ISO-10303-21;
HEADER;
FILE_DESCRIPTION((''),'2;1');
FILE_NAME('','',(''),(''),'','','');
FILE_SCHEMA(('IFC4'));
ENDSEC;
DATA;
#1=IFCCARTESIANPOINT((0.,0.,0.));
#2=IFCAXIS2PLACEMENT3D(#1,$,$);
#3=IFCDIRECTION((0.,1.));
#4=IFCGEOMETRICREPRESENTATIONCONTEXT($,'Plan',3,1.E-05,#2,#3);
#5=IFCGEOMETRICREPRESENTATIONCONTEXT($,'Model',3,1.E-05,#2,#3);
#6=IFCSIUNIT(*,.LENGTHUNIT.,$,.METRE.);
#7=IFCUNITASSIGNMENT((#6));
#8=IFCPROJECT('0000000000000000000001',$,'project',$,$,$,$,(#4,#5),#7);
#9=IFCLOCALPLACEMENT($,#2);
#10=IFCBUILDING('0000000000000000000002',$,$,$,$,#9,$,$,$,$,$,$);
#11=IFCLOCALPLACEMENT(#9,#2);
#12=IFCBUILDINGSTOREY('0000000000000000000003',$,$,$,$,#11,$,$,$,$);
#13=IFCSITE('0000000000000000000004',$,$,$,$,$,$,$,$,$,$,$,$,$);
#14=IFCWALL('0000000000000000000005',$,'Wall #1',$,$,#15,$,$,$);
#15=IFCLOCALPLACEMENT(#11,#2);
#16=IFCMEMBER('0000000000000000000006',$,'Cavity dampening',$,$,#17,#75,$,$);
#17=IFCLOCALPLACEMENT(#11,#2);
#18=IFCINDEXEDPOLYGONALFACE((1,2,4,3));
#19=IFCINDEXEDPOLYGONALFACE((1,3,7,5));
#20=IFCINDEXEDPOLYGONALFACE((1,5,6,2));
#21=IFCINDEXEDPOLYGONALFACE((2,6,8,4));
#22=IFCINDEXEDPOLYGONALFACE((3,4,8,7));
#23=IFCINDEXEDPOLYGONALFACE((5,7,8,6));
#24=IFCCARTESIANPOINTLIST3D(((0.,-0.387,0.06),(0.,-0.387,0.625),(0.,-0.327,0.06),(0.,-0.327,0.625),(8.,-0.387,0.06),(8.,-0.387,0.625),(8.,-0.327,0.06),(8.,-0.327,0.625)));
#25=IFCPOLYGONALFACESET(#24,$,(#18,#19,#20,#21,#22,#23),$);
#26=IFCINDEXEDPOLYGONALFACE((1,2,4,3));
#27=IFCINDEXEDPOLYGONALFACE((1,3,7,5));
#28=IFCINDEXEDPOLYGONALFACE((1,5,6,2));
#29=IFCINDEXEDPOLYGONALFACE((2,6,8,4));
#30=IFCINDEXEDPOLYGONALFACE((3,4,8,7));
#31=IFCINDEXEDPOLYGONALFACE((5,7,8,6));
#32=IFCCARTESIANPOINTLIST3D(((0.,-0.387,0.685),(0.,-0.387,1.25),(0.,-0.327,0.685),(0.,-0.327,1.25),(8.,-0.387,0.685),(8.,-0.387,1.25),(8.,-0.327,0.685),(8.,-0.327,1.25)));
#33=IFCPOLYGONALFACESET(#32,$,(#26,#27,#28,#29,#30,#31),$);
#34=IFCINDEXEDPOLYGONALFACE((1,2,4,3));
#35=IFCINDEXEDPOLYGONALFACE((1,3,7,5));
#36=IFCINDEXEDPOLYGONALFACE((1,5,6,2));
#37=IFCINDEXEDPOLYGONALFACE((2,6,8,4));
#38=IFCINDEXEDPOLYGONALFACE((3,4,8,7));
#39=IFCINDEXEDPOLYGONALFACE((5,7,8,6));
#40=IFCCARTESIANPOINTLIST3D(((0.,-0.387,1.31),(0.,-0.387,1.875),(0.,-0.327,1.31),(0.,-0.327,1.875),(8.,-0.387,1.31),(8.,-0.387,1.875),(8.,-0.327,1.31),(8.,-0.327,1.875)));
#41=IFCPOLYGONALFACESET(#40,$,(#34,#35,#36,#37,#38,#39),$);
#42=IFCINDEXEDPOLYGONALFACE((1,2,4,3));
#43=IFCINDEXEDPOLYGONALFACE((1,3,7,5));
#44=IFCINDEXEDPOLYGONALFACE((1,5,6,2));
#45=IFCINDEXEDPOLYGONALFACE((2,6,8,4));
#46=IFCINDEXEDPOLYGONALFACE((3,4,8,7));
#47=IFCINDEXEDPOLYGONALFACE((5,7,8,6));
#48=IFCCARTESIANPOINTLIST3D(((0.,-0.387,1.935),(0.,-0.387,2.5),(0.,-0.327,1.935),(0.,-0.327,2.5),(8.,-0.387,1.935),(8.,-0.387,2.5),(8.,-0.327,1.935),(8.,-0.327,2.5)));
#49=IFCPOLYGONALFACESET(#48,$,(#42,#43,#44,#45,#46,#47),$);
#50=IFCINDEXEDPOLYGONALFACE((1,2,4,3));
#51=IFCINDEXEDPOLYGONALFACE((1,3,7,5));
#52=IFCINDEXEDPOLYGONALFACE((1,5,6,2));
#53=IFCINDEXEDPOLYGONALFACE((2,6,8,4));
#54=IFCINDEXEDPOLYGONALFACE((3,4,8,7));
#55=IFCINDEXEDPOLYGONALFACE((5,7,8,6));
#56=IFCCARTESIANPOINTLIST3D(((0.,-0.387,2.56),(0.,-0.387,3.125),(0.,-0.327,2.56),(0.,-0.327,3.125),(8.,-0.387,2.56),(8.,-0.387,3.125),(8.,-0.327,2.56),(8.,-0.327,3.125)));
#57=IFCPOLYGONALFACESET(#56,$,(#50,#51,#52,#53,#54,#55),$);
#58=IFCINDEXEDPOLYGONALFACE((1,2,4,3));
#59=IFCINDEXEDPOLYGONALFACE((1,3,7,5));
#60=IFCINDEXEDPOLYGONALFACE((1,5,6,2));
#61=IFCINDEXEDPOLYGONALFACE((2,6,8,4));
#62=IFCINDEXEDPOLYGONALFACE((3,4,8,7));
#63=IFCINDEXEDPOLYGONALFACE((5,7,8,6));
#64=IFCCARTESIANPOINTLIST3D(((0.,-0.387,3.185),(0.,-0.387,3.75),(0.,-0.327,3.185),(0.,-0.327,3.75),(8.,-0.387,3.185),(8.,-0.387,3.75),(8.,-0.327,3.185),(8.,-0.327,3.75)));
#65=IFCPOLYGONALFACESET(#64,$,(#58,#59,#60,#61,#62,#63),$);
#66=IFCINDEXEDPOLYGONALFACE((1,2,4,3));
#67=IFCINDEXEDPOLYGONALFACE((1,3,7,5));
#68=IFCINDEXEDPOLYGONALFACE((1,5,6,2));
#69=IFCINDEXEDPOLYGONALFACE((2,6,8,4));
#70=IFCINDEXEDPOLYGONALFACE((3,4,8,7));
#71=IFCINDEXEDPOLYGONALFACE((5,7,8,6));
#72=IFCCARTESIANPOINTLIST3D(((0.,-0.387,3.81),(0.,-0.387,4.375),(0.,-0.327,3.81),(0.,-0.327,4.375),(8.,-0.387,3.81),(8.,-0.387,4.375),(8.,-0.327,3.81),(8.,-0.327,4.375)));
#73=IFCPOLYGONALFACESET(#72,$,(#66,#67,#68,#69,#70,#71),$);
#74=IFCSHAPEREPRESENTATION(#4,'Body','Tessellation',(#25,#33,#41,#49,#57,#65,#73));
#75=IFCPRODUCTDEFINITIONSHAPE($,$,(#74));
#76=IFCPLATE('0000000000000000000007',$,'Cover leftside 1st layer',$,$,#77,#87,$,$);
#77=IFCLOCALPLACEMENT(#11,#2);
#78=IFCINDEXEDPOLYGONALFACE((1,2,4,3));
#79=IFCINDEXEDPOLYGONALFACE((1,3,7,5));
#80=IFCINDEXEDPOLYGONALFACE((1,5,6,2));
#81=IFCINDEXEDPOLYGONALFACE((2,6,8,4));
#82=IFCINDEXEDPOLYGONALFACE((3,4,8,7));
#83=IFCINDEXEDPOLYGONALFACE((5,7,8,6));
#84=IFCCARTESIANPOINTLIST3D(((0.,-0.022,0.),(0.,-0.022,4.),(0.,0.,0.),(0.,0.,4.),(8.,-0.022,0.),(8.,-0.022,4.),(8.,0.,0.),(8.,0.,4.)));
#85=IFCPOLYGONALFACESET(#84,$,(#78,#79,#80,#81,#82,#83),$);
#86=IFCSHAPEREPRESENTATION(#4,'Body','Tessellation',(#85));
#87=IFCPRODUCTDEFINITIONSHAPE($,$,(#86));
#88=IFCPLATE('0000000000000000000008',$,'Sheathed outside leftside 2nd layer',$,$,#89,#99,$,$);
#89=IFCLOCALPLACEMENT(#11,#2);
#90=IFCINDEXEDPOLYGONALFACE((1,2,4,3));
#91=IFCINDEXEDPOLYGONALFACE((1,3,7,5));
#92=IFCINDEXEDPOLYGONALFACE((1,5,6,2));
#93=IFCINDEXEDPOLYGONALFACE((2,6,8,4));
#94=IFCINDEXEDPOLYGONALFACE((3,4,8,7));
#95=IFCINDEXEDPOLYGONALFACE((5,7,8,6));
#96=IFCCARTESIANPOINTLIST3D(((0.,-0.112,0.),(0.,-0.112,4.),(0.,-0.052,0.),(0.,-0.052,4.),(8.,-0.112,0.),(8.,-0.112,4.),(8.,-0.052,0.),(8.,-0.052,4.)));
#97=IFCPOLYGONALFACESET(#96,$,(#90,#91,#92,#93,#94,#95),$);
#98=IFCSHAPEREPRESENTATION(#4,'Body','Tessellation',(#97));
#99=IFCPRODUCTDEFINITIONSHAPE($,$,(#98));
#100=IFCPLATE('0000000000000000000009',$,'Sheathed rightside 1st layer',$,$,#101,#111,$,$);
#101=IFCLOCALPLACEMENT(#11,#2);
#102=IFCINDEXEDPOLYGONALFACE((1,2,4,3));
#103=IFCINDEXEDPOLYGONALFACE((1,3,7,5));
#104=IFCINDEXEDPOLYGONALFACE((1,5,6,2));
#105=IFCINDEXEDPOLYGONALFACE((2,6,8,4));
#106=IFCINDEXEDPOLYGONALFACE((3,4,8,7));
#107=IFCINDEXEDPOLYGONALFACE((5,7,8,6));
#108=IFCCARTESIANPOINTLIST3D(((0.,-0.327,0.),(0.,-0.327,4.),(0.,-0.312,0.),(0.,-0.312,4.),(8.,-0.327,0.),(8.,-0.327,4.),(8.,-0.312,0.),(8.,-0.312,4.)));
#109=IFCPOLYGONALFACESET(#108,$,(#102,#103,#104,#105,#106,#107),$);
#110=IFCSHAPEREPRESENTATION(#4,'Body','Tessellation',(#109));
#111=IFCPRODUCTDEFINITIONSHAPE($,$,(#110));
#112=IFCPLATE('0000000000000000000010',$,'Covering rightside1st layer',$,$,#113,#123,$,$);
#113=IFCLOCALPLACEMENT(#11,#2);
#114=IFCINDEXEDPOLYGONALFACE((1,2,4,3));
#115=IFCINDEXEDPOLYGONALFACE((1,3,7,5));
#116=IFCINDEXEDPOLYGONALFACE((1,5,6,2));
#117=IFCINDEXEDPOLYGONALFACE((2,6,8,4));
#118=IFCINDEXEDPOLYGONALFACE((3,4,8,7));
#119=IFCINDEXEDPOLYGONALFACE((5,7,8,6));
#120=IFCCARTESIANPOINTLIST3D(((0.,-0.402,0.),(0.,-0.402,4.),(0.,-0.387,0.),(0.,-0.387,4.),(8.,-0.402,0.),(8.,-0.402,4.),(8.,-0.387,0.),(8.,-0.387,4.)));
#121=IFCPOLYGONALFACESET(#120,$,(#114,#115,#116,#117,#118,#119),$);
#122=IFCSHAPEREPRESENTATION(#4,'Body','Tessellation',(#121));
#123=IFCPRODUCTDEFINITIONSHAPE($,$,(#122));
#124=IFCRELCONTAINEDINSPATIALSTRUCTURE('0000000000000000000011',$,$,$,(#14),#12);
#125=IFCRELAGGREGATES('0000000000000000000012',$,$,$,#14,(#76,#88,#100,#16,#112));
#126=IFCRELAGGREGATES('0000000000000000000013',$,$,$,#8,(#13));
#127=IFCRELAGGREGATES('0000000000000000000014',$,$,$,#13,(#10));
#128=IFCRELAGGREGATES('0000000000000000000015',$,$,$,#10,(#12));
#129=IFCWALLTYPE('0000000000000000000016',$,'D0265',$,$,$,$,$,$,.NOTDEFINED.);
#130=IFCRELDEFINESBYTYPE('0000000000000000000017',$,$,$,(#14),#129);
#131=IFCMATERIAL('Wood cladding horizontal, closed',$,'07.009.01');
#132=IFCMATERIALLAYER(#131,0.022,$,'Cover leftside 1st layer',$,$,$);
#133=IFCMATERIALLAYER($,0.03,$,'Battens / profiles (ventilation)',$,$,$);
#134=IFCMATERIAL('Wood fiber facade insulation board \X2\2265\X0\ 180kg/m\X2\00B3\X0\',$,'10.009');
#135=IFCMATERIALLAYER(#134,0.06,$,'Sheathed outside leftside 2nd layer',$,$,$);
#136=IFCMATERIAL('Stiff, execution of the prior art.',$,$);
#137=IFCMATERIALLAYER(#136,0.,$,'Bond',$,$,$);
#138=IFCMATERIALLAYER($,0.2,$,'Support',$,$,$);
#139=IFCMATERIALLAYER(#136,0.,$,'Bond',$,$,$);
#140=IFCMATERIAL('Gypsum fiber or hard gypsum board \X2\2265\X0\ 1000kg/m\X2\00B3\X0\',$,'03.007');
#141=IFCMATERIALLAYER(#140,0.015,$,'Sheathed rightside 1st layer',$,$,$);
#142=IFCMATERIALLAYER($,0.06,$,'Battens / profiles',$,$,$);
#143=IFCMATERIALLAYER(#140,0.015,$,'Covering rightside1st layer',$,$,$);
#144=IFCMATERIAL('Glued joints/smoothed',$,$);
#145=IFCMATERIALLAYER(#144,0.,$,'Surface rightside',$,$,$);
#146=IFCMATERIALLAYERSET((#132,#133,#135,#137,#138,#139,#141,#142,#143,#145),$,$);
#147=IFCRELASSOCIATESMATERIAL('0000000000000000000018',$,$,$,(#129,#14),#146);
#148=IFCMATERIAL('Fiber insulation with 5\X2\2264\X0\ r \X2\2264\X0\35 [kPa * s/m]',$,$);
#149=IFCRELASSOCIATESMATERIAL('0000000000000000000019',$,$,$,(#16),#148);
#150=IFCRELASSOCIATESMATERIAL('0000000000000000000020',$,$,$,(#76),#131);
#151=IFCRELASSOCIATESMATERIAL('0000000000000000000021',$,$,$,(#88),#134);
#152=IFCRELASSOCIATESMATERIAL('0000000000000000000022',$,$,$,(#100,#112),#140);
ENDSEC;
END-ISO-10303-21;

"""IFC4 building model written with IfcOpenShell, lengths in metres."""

from ifc_helpers import new_model, si_unit, direction, frame, frame_2d, origin, origin_with_axes, place, context, project, spatial, rectangle, extrude, material, layer, layer_set, type_object, element, aggregate, save


model = new_model("IFC4")

# Units and contexts
plan_context = context("Plan", 3, precision=1e-05, world=origin(), true_north=direction((0.0, 1.0)))
model_context = context("Model", 3, precision=1e-05, world=origin(), true_north=direction((0.0, 1.0)))
ifc_project = project(units=[si_unit("LENGTHUNIT", "METRE")], contexts=[plan_context, model_context])

# Site, building, storey
site = spatial("IfcSite", under=ifc_project)
building_placement = place(None, origin())
building = spatial("IfcBuilding", under=site, at=building_placement)
storey_placement = place(building_placement, origin())
storey = spatial("IfcBuildingStorey", under=building, at=storey_placement)

# Wall, member, plates
ifc_material_1 = material(Name="Wood cladding horizontal, closed", Category="07.009.01")
ifc_layer_1 = layer(ifc_material_1, 0.022, Name="Cover leftside 1st layer")
ifc_layer_2 = layer(None, 0.03, Name="Battens / profiles (ventilation)")
ifc_material_2 = material(Name="Wood fiber facade insulation board ≥ 180kg/m³", Category="10.009")
ifc_layer_3 = layer(ifc_material_2, 0.06, Name="Sheathed outside leftside 2nd layer")
ifc_material_3 = material(Name="Stiff, execution of the prior art.")
ifc_layer_4 = layer(ifc_material_3, 0.0, Name="Bond")
ifc_layer_5 = layer(None, 0.2, Name="Support")
ifc_layer_6 = layer(ifc_material_3, 0.0, Name="Bond")
ifc_material_4 = material(Name="Gypsum fiber or hard gypsum board ≥ 1000kg/m³", Category="03.007")
ifc_layer_7 = layer(ifc_material_4, 0.015, Name="Sheathed rightside 1st layer")
ifc_layer_8 = layer(None, 0.06, Name="Battens / profiles")
ifc_layer_9 = layer(ifc_material_4, 0.015, Name="Covering rightside1st layer")
ifc_material_5 = material(Name="Glued joints/smoothed")
ifc_layer_10 = layer(ifc_material_5, 0.0, Name="Surface rightside")
ifc_layer_set = layer_set([ifc_layer_1, ifc_layer_2, ifc_layer_3, ifc_layer_4, ifc_layer_5, ifc_layer_6, ifc_layer_7, ifc_layer_8, ifc_layer_9, ifc_layer_10])
wall_type = type_object("IfcWallType", Name="D0265", PredefinedType="NOTDEFINED", material=ifc_layer_set)
wall_placement = place(None, frame((0.0, 0.0, 0.0), z_axis=(0.0, -1.0, 0.0), x_axis=(1.0, 0.0, 0.0)))
wall = element("IfcWall", 1, at=wall_placement, inside=storey, type_object=wall_type, material=ifc_layer_set, Name="Wall #1")
ifc_material_6 = material(Name="Fiber insulation with 5≤ r ≤35 [kPa * s/m]")
member_1_placement = place(wall_placement, origin())
member_1 = element("IfcMember", 2, at=member_1_placement, material=ifc_material_6, Name="Cavity dampening", context=plan_context, shape_type="SweptSolid", body=[
    extrude(rectangle(XDim=0.565, YDim=0.06, at=frame_2d((0.2825, 0.03), x_axis=(1.0, 0.0))), frame((0.0, 0.06, 0.327), z_axis=(1.0, 0.0, 0.0), x_axis=(0.0, 1.0, 0.0)), (0.0, 0.0, 1.0), 8.0),
    extrude(rectangle(XDim=0.565, YDim=0.06, at=frame_2d((0.2825, 0.03), x_axis=(1.0, 0.0))), frame((0.0, 0.685, 0.327), z_axis=(1.0, 0.0, 0.0), x_axis=(0.0, 1.0, 0.0)), (0.0, 0.0, 1.0), 8.0),
    extrude(rectangle(XDim=0.565, YDim=0.06, at=frame_2d((0.2825, 0.03), x_axis=(1.0, 0.0))), frame((0.0, 1.31, 0.327), z_axis=(1.0, 0.0, 0.0), x_axis=(0.0, 1.0, 0.0)), (0.0, 0.0, 1.0), 8.0),
    extrude(rectangle(XDim=0.565, YDim=0.06, at=frame_2d((0.2825, 0.03), x_axis=(1.0, 0.0))), frame((0.0, 1.935, 0.327), z_axis=(1.0, 0.0, 0.0), x_axis=(0.0, 1.0, 0.0)), (0.0, 0.0, 1.0), 8.0),
    extrude(rectangle(XDim=0.565, YDim=0.06, at=frame_2d((0.2825, 0.03), x_axis=(1.0, 0.0))), frame((0.0, 2.56, 0.327), z_axis=(1.0, 0.0, 0.0), x_axis=(0.0, 1.0, 0.0)), (0.0, 0.0, 1.0), 8.0),
    extrude(rectangle(XDim=0.565, YDim=0.06, at=frame_2d((0.2825, 0.03), x_axis=(1.0, 0.0))), frame((0.0, 3.185, 0.327), z_axis=(1.0, 0.0, 0.0), x_axis=(0.0, 1.0, 0.0)), (0.0, 0.0, 1.0), 8.0),
    extrude(rectangle(XDim=0.565, YDim=0.06, at=frame_2d((0.2825, 0.03), x_axis=(1.0, 0.0))), frame((0.0, 3.81, 0.327), z_axis=(1.0, 0.0, 0.0), x_axis=(0.0, 1.0, 0.0)), (0.0, 0.0, 1.0), 8.0),
])
plate_1_placement = place(wall_placement, origin())
plate_1 = element("IfcPlate", 3, at=plate_1_placement, material=ifc_material_1, Name="Cover leftside 1st layer", context=plan_context, shape_type="SweptSolid", body=[
    extrude(rectangle(XDim=8.0, YDim=4.0, at=frame_2d((4.0, 2.0), x_axis=(1.0, 0.0))), origin_with_axes(), (0.0, 0.0, 1.0), 0.022),
])
plate_2_placement = place(wall_placement, origin())
plate_2 = element("IfcPlate", 4, at=plate_2_placement, material=ifc_material_2, Name="Sheathed outside leftside 2nd layer", context=plan_context, shape_type="SweptSolid", body=[
    extrude(rectangle(XDim=8.0, YDim=4.0, at=frame_2d((4.0, 2.0), x_axis=(1.0, 0.0))), frame((0.0, 0.0, 0.052), z_axis=(0.0, 0.0, 1.0), x_axis=(1.0, 0.0, 0.0)), (0.0, 0.0, 1.0), 0.06),
])
plate_3_placement = place(wall_placement, origin())
plate_3 = element("IfcPlate", 5, at=plate_3_placement, material=ifc_material_4, Name="Sheathed rightside 1st layer", context=plan_context, shape_type="SweptSolid", body=[
    extrude(rectangle(XDim=8.0, YDim=4.0, at=frame_2d((4.0, 2.0), x_axis=(1.0, 0.0))), frame((0.0, 0.0, 0.312), z_axis=(0.0, 0.0, 1.0), x_axis=(1.0, 0.0, 0.0)), (0.0, 0.0, 1.0), 0.015),
])
plate_4_placement = place(wall_placement, origin())
plate_4 = element("IfcPlate", 6, at=plate_4_placement, material=ifc_material_4, Name="Covering rightside1st layer", context=plan_context, shape_type="SweptSolid", body=[
    extrude(rectangle(XDim=8.0, YDim=4.0, at=frame_2d((4.0, 2.0), x_axis=(1.0, 0.0))), frame((0.0, 0.0, 0.387), z_axis=(0.0, 0.0, 1.0), x_axis=(1.0, 0.0, 0.0)), (0.0, 0.0, 1.0), 0.015),
])
aggregate(wall, [plate_1, plate_2, plate_3, member_1, plate_4])

save(model, "model.ifc")
